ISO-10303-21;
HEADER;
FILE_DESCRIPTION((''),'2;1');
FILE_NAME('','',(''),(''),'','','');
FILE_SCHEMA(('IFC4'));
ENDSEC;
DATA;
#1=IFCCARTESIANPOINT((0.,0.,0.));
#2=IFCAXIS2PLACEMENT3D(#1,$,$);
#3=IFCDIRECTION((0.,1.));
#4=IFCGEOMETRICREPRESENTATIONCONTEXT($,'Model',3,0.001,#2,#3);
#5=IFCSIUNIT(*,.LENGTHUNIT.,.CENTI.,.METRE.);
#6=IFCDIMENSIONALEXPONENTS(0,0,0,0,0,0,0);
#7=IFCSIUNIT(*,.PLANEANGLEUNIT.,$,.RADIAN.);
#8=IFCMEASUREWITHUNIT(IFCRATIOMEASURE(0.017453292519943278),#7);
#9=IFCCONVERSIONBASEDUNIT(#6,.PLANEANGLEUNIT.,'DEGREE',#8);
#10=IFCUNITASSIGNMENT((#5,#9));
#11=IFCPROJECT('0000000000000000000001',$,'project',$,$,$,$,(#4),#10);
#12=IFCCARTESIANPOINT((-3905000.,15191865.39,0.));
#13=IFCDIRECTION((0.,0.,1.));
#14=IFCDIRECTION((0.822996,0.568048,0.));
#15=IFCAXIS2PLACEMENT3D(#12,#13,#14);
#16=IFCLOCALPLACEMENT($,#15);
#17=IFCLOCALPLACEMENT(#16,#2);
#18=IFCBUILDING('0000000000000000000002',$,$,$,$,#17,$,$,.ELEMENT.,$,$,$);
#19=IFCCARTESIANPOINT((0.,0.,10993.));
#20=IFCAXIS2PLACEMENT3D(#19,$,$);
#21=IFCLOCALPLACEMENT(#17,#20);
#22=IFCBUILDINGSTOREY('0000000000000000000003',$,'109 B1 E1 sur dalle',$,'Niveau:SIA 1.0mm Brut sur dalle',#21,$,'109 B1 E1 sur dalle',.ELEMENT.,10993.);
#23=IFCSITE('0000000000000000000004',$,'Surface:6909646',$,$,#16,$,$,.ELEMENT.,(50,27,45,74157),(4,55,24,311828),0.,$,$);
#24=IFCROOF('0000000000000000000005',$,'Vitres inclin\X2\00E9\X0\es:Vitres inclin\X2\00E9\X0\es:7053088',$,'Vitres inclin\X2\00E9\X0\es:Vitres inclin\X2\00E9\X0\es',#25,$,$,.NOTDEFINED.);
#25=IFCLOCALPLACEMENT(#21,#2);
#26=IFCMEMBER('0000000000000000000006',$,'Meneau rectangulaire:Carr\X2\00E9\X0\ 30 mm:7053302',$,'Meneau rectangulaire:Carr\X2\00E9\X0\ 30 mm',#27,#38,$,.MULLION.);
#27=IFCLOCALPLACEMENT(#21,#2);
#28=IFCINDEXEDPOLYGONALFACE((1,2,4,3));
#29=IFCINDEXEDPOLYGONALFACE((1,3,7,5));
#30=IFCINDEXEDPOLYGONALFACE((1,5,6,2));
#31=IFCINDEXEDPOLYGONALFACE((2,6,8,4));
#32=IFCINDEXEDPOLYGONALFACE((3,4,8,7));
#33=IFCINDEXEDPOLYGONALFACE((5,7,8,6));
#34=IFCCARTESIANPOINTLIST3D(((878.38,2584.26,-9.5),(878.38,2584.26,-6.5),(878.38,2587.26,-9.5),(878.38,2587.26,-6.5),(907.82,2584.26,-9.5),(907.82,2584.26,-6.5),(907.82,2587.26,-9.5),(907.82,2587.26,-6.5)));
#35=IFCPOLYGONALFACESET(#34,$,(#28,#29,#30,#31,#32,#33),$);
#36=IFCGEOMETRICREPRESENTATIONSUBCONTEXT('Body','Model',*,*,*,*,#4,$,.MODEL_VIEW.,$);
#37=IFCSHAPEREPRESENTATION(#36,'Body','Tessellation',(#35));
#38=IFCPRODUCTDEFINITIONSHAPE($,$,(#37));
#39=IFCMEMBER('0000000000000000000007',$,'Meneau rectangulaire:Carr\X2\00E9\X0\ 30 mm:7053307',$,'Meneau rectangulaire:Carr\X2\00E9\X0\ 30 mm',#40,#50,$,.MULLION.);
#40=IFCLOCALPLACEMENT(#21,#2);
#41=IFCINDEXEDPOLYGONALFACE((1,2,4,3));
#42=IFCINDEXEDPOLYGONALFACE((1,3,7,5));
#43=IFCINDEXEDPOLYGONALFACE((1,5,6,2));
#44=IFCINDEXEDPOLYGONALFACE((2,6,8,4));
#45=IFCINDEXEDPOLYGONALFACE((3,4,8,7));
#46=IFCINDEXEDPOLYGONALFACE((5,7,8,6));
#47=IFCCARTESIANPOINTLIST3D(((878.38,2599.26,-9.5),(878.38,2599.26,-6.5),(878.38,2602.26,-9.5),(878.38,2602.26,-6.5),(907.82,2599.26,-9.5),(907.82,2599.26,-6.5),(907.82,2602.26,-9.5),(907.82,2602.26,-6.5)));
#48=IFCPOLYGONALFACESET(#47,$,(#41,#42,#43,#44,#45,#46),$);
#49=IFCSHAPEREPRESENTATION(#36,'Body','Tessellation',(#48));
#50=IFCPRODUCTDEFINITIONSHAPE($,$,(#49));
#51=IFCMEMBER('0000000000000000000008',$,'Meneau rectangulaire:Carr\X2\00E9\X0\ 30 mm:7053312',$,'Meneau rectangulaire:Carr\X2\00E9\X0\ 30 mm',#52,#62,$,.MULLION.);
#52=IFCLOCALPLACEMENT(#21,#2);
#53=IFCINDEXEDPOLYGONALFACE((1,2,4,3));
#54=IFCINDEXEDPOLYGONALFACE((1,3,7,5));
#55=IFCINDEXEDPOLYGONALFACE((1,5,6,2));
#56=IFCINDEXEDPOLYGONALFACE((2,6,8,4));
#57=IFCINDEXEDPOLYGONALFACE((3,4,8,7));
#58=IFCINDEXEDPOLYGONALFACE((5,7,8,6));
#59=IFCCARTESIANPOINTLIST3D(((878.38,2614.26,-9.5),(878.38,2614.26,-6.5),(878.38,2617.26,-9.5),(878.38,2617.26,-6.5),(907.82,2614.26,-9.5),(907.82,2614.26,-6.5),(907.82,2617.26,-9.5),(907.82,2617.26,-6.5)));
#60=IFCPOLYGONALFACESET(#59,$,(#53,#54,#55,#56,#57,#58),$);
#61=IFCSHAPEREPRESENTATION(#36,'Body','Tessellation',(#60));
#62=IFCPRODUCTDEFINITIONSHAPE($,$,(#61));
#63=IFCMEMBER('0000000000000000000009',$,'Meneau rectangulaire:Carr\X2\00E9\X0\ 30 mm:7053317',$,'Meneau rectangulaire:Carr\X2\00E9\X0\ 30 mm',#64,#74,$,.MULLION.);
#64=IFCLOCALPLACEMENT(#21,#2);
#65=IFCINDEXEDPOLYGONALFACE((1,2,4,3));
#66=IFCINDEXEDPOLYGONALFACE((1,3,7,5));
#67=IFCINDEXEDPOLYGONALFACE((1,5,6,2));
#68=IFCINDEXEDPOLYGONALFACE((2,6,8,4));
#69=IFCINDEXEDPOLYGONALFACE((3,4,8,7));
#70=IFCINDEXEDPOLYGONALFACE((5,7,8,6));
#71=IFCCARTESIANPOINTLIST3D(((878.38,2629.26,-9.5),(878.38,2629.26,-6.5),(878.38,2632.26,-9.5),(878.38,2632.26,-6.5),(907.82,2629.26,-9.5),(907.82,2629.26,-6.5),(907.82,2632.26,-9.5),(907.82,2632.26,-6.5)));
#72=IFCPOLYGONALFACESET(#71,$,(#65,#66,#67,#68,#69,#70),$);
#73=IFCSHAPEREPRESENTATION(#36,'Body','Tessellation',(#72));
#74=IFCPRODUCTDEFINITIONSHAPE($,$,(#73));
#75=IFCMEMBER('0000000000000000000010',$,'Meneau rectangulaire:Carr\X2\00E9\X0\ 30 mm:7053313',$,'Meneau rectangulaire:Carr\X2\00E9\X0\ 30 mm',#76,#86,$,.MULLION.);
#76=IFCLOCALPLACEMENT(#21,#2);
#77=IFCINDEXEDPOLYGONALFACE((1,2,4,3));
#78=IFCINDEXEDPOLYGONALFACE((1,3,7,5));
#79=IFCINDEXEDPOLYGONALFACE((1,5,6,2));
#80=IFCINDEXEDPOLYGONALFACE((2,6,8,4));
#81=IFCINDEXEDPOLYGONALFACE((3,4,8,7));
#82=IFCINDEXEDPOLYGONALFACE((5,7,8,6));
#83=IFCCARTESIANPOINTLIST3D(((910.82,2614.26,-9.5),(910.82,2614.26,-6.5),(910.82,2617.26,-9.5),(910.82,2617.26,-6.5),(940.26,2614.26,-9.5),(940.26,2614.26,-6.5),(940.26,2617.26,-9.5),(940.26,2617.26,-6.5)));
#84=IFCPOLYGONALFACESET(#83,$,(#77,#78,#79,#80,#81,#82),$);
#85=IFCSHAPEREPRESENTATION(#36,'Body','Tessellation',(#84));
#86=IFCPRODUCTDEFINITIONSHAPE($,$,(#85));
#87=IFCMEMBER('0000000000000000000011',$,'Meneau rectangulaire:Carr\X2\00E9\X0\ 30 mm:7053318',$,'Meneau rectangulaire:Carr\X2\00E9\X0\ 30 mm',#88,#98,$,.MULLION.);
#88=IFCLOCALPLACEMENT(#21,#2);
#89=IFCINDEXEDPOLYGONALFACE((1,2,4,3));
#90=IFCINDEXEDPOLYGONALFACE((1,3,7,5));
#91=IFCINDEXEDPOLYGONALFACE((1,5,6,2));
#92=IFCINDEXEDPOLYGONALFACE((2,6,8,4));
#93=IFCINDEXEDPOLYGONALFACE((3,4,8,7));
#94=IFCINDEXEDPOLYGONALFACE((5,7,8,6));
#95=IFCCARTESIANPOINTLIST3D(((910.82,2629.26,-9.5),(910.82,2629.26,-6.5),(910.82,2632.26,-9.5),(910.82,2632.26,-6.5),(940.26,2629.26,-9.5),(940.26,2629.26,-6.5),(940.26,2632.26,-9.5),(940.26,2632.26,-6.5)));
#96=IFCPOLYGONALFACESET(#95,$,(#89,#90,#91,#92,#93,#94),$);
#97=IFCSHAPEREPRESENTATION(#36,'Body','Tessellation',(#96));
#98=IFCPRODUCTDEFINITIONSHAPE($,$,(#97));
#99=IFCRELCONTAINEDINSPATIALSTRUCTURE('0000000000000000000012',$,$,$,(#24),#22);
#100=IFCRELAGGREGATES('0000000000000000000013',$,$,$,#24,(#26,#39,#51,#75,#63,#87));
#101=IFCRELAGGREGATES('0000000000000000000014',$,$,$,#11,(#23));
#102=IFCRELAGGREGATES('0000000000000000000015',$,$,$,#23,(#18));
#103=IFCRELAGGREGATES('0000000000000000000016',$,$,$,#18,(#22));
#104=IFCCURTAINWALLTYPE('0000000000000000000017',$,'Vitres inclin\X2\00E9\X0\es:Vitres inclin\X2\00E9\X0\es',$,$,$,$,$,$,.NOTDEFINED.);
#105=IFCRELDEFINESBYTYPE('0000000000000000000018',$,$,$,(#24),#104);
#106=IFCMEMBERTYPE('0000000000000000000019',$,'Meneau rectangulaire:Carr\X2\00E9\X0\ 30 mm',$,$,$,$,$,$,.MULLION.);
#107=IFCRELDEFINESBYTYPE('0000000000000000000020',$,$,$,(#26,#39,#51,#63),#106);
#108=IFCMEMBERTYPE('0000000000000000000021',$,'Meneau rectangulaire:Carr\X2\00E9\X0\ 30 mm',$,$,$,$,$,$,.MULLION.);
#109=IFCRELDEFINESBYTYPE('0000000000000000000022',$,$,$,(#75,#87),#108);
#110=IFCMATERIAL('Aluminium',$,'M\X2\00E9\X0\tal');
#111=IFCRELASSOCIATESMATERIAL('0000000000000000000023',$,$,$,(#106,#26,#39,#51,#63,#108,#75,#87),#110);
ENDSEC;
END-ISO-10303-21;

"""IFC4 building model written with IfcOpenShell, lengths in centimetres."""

from ifc_helpers import new_model, entity, si_unit, converted_unit, direction, frame, origin, place, context, subcontext, project, spatial, indexed_curve, outline, extrude, source, transform, mapped, material, type_object, type_shapes, element, aggregate, save


model = new_model("IFC4")

# Units and contexts
model_context = context("Model", 3, precision=0.001, world=origin(), true_north=direction((0.0, 1.0)))
body_context = subcontext(model_context, "Body", "Model", "MODEL_VIEW")
ifc_project = project(units=[si_unit("LENGTHUNIT", "METRE", prefix="CENTI"), converted_unit("PLANEANGLEUNIT", "DEGREE", entity("IfcRatioMeasure", 0.017453292519943278), si_unit("PLANEANGLEUNIT", "RADIAN"), dimensions=[0, 0, 0, 0, 0, 0, 0])], contexts=[model_context])

# Site, building, storey
site_placement = place(None, frame((-3905000.0, 15191865.39, 0.0), z_axis=(0.0, 0.0, 1.0), x_axis=(0.822996, 0.568048, 0.0)))
site = spatial("IfcSite", under=ifc_project, at=site_placement, Name="Surface:6909646", CompositionType="ELEMENT", RefLatitude=(50, 27, 45, 74157), RefLongitude=(4, 55, 24, 311828), RefElevation=0.0)
building_placement = place(site_placement, origin())
building = spatial("IfcBuilding", under=site, at=building_placement, CompositionType="ELEMENT")
storey_placement = place(building_placement, frame((0.0, 0.0, 10993.0)))
storey = spatial("IfcBuildingStorey", under=building, at=storey_placement, Name="109 B1 E1 sur dalle", ObjectType="Niveau:SIA 1.0mm Brut sur dalle", LongName="109 B1 E1 sur dalle", CompositionType="ELEMENT", Elevation=10993.0)

# Roof
curtain_wall_type = type_object("IfcCurtainWallType", Name="Vitres inclinées:Vitres inclinées", PredefinedType="NOTDEFINED")
ifc_material = material(Name="Aluminium", Category="Métal")
roof_1_placement = place(storey_placement, frame((0.0, 0.0, -10993.0)))
roof_1 = element("IfcRoof", 1, at=roof_1_placement, inside=storey, type_object=curtain_wall_type, Name="Vitres inclinées:Vitres inclinées:7053088", ObjectType="Vitres inclinées:Vitres inclinées", PredefinedType="NOTDEFINED")

# Members
member_type_1 = type_object("IfcMemberType", Name="Meneau rectangulaire:Carré 30 mm", PredefinedType="MULLION", material=ifc_material)
shared_shape_1 = source(origin(), body_context, "Body", "SweptSolid", [
    extrude(outline(indexed_curve([(-1.5, -1.5), (1.5, -1.5), (1.5, 1.5), (-1.5, 1.5), (-1.5, -1.5)], self_intersect=False)), frame((0.0, 0.0, -29.44), z_axis=(0.0, 0.0, 1.0), x_axis=(0.0, -1.0, 0.0)), (0.0, 0.0, 1.0), 29.44),
])
type_shapes(member_type_1, [shared_shape_1])
member_1_placement = place(roof_1_placement, frame((878.38, 2585.76, 10985.0), z_axis=(-1.0, 0.0, 0.0), x_axis=(0.0, 1.0, 0.0)))
member_1 = element("IfcMember", 2, at=member_1_placement, type_object=member_type_1, material=ifc_material, Name="Meneau rectangulaire:Carré 30 mm:7053302", ObjectType="Meneau rectangulaire:Carré 30 mm", PredefinedType="MULLION", context=body_context, shape_type="MappedRepresentation", body=[
    mapped(shared_shape_1, transform((0.0, 0.0, 0.0), scale=1.0)),
])
member_2_placement = place(roof_1_placement, frame((878.38, 2600.76, 10985.0), z_axis=(-1.0, 0.0, 0.0), x_axis=(0.0, 1.0, 0.0)))
member_2 = element("IfcMember", 3, at=member_2_placement, type_object=member_type_1, material=ifc_material, Name="Meneau rectangulaire:Carré 30 mm:7053307", ObjectType="Meneau rectangulaire:Carré 30 mm", PredefinedType="MULLION", context=body_context, shape_type="MappedRepresentation", body=[
    mapped(shared_shape_1, transform((0.0, 0.0, 0.0), scale=1.0)),
])
member_3_placement = place(roof_1_placement, frame((878.38, 2615.76, 10985.0), z_axis=(-1.0, 0.0, 0.0), x_axis=(0.0, 1.0, 0.0)))
member_3 = element("IfcMember", 4, at=member_3_placement, type_object=member_type_1, material=ifc_material, Name="Meneau rectangulaire:Carré 30 mm:7053312", ObjectType="Meneau rectangulaire:Carré 30 mm", PredefinedType="MULLION", context=body_context, shape_type="MappedRepresentation", body=[
    mapped(shared_shape_1, transform((0.0, 0.0, 0.0), scale=1.0)),
])
member_4_placement = place(roof_1_placement, frame((878.38, 2630.76, 10985.0), z_axis=(-1.0, 0.0, 0.0), x_axis=(0.0, 1.0, 0.0)))
member_4 = element("IfcMember", 5, at=member_4_placement, type_object=member_type_1, material=ifc_material, Name="Meneau rectangulaire:Carré 30 mm:7053317", ObjectType="Meneau rectangulaire:Carré 30 mm", PredefinedType="MULLION", context=body_context, shape_type="MappedRepresentation", body=[
    mapped(shared_shape_1, transform((0.0, 0.0, 0.0), scale=1.0)),
])
member_type_2 = type_object("IfcMemberType", Name="Meneau rectangulaire:Carré 30 mm", PredefinedType="MULLION", material=ifc_material)
shared_shape_2 = source(origin(), body_context, "Body", "SweptSolid", [
    extrude(outline(indexed_curve([(-1.5, -1.5), (1.5, -1.5), (1.5, 1.5), (-1.5, 1.5), (-1.5, -1.5)], self_intersect=False)), frame((0.0, 0.0, -29.44), z_axis=(0.0, 0.0, 1.0), x_axis=(0.0, -1.0, 0.0)), (0.0, 0.0, 1.0), 29.44),
])
type_shapes(member_type_2, [shared_shape_2])
member_5_placement = place(roof_1_placement, frame((910.82, 2615.76, 10985.0), z_axis=(-1.0, 0.0, 0.0), x_axis=(0.0, 1.0, 0.0)))
member_5 = element("IfcMember", 6, at=member_5_placement, type_object=member_type_2, material=ifc_material, Name="Meneau rectangulaire:Carré 30 mm:7053313", ObjectType="Meneau rectangulaire:Carré 30 mm", PredefinedType="MULLION", context=body_context, shape_type="MappedRepresentation", body=[
    mapped(shared_shape_2, transform((0.0, 0.0, 0.0), scale=1.0)),
])
member_6_placement = place(roof_1_placement, frame((910.82, 2630.76, 10985.0), z_axis=(-1.0, 0.0, 0.0), x_axis=(0.0, 1.0, 0.0)))
member_6 = element("IfcMember", 7, at=member_6_placement, type_object=member_type_2, material=ifc_material, Name="Meneau rectangulaire:Carré 30 mm:7053318", ObjectType="Meneau rectangulaire:Carré 30 mm", PredefinedType="MULLION", context=body_context, shape_type="MappedRepresentation", body=[
    mapped(shared_shape_2, transform((0.0, 0.0, 0.0), scale=1.0)),
])
aggregate(roof_1, [member_1, member_2, member_3, member_5, member_4, member_6])

save(model, "model.ifc")
